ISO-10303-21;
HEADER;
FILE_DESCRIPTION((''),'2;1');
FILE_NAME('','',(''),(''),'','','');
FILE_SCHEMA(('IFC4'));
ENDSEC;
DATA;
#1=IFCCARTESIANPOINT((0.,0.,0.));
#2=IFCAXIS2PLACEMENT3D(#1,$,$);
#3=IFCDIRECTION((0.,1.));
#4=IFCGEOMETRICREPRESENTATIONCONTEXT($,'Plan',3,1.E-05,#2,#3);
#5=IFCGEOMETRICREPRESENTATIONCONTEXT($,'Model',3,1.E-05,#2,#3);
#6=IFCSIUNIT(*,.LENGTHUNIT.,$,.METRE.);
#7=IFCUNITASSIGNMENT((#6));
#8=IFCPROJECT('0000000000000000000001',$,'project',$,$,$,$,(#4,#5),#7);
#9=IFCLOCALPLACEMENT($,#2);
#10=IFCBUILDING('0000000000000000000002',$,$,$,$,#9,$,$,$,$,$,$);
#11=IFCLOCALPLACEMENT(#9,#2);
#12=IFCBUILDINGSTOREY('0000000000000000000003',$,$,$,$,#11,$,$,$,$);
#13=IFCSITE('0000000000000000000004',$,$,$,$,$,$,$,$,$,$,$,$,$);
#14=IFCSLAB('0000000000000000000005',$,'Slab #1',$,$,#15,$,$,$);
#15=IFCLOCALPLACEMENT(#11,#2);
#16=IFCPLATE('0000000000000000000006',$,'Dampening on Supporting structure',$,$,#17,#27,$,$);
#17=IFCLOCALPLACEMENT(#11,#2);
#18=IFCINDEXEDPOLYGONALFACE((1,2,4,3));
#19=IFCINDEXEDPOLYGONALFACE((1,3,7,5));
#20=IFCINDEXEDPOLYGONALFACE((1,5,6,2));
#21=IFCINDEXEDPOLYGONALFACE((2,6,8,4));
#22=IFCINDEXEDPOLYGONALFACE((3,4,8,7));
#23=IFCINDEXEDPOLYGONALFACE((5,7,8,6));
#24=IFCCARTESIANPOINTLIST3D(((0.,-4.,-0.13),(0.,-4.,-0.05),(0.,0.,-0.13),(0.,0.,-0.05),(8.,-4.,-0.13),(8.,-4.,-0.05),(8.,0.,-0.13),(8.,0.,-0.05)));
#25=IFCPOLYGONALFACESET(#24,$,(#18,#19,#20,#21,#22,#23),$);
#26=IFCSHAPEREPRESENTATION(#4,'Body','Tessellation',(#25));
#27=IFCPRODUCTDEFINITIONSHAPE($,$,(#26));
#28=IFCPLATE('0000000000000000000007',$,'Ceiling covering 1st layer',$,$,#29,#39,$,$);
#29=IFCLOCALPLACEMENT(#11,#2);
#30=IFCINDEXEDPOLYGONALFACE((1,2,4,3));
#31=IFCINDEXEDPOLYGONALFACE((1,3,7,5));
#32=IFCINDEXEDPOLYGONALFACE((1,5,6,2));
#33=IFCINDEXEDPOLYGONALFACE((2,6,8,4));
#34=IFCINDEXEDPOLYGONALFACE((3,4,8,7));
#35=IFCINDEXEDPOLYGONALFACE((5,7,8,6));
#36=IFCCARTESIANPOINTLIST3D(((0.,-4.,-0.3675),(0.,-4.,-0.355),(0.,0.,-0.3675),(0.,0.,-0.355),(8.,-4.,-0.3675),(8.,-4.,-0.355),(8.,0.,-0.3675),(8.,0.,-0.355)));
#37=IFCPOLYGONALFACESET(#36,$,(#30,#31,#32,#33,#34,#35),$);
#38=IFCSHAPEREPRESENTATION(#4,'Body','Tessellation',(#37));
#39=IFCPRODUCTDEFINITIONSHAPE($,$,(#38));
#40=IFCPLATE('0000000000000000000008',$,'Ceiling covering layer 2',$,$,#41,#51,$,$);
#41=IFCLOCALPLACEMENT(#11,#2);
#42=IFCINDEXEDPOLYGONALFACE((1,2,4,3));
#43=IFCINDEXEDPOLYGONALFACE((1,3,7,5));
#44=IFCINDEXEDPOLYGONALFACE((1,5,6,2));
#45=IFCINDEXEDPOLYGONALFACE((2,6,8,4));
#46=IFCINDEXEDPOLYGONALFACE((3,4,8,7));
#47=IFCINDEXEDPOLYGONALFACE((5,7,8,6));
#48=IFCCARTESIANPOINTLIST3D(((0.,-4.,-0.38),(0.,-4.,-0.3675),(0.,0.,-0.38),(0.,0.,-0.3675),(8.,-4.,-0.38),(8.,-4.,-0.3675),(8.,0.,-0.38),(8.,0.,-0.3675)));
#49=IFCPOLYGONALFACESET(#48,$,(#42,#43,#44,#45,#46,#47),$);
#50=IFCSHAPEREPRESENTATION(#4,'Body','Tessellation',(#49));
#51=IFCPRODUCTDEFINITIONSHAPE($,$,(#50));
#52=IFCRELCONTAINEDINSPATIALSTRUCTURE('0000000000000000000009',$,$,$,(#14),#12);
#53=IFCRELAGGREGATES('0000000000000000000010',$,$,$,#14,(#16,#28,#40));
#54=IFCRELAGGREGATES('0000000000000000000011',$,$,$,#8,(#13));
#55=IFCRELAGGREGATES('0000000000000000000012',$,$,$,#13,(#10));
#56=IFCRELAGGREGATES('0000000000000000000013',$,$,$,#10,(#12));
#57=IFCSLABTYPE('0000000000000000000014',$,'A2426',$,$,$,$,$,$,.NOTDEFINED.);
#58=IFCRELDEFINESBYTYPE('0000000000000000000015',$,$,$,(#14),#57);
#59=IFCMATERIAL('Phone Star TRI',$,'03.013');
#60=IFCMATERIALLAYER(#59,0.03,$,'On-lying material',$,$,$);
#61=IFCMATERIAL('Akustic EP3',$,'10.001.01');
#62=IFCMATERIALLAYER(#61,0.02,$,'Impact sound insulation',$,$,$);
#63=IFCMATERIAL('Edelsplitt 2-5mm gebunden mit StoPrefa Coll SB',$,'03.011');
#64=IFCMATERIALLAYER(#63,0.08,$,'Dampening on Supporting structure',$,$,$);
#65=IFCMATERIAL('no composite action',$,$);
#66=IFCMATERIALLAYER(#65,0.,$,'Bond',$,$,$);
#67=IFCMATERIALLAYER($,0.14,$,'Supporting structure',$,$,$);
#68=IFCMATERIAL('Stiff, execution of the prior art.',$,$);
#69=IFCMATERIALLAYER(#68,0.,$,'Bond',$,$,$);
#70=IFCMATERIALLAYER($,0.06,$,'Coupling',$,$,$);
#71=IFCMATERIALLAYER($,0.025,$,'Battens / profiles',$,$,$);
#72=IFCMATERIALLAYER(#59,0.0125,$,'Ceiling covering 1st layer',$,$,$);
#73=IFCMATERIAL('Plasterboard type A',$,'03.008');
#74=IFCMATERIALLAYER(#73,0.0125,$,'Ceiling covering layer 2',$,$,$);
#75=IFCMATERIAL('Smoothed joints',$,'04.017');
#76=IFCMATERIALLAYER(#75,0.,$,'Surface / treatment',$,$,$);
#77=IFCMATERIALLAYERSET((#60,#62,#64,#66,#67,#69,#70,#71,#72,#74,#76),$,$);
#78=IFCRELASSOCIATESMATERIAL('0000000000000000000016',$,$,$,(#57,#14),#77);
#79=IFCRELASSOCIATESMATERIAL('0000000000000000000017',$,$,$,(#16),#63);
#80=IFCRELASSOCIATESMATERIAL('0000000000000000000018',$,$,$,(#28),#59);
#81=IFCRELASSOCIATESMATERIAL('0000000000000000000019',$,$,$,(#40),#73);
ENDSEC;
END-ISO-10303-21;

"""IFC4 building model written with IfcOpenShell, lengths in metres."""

from ifc_helpers import new_model, si_unit, direction, frame, frame_2d, origin, place, context, project, spatial, rectangle, extrude, material, layer, layer_set, type_object, element, aggregate, save


model = new_model("IFC4")

# Units and contexts
plan_context = context("Plan", 3, precision=1e-05, world=origin(), true_north=direction((0.0, 1.0)))
model_context = context("Model", 3, precision=1e-05, world=origin(), true_north=direction((0.0, 1.0)))
ifc_project = project(units=[si_unit("LENGTHUNIT", "METRE")], contexts=[plan_context, model_context])

# Site, building, storey
site = spatial("IfcSite", under=ifc_project)
building_placement = place(None, origin())
building = spatial("IfcBuilding", under=site, at=building_placement)
storey_placement = place(building_placement, origin())
storey = spatial("IfcBuildingStorey", under=building, at=storey_placement)

# Slab, plates
ifc_material_1 = material(Name="Phone Star TRI", Category="03.013")
ifc_layer_1 = layer(ifc_material_1, 0.03, Name="On-lying material")
ifc_material_2 = material(Name="Akustic EP3", Category="10.001.01")
ifc_layer_2 = layer(ifc_material_2, 0.02, Name="Impact sound insulation")
ifc_material_3 = material(Name="Edelsplitt 2-5mm gebunden mit StoPrefa Coll SB", Category="03.011")
ifc_layer_3 = layer(ifc_material_3, 0.08, Name="Dampening on Supporting structure")
ifc_material_4 = material(Name="no composite action")
ifc_layer_4 = layer(ifc_material_4, 0.0, Name="Bond")
ifc_layer_5 = layer(None, 0.14, Name="Supporting structure")
ifc_material_5 = material(Name="Stiff, execution of the prior art.")
ifc_layer_6 = layer(ifc_material_5, 0.0, Name="Bond")
ifc_layer_7 = layer(None, 0.06, Name="Coupling")
ifc_layer_8 = layer(None, 0.025, Name="Battens / profiles")
ifc_layer_9 = layer(ifc_material_1, 0.0125, Name="Ceiling covering 1st layer")
ifc_material_6 = material(Name="Plasterboard type A", Category="03.008")
ifc_layer_10 = layer(ifc_material_6, 0.0125, Name="Ceiling covering layer 2")
ifc_material_7 = material(Name="Smoothed joints", Category="04.017")
ifc_layer_11 = layer(ifc_material_7, 0.0, Name="Surface / treatment")
ifc_layer_set = layer_set([ifc_layer_1, ifc_layer_2, ifc_layer_3, ifc_layer_4, ifc_layer_5, ifc_layer_6, ifc_layer_7, ifc_layer_8, ifc_layer_9, ifc_layer_10, ifc_layer_11])
slab_type = type_object("IfcSlabType", Name="A2426", PredefinedType="NOTDEFINED", material=ifc_layer_set)
slab_placement = place(None, frame((0.0, 0.0, 0.0), z_axis=(0.0, 0.0, -1.0), x_axis=(1.0, 0.0, 0.0)))
slab = element("IfcSlab", 1, at=slab_placement, inside=storey, type_object=slab_type, material=ifc_layer_set, Name="Slab #1")
plate_1_placement = place(slab_placement, origin())
plate_1 = element("IfcPlate", 2, at=plate_1_placement, material=ifc_material_3, Name="Dampening on Supporting structure", context=plan_context, shape_type="SweptSolid", body=[
    extrude(rectangle(XDim=8.0, YDim=4.0, at=frame_2d((4.0, 2.0), x_axis=(1.0, 0.0))), frame((0.0, 0.0, 0.05), z_axis=(0.0, 0.0, 1.0), x_axis=(1.0, 0.0, 0.0)), (0.0, 0.0, 1.0), 0.08),
])
plate_2_placement = place(slab_placement, origin())
plate_2 = element("IfcPlate", 3, at=plate_2_placement, material=ifc_material_1, Name="Ceiling covering 1st layer", context=plan_context, shape_type="SweptSolid", body=[
    extrude(rectangle(XDim=8.0, YDim=4.0, at=frame_2d((4.0, 2.0), x_axis=(1.0, 0.0))), frame((0.0, 0.0, 0.355), z_axis=(0.0, 0.0, 1.0), x_axis=(1.0, 0.0, 0.0)), (0.0, 0.0, 1.0), 0.0125),
])
plate_3_placement = place(slab_placement, origin())
plate_3 = element("IfcPlate", 4, at=plate_3_placement, material=ifc_material_6, Name="Ceiling covering layer 2", context=plan_context, shape_type="SweptSolid", body=[
    extrude(rectangle(XDim=8.0, YDim=4.0, at=frame_2d((4.0, 2.0), x_axis=(1.0, 0.0))), frame((0.0, 0.0, 0.3675), z_axis=(0.0, 0.0, 1.0), x_axis=(1.0, 0.0, 0.0)), (0.0, 0.0, 1.0), 0.0125),
])
aggregate(slab, [plate_1, plate_2, plate_3])

save(model, "model.ifc")
